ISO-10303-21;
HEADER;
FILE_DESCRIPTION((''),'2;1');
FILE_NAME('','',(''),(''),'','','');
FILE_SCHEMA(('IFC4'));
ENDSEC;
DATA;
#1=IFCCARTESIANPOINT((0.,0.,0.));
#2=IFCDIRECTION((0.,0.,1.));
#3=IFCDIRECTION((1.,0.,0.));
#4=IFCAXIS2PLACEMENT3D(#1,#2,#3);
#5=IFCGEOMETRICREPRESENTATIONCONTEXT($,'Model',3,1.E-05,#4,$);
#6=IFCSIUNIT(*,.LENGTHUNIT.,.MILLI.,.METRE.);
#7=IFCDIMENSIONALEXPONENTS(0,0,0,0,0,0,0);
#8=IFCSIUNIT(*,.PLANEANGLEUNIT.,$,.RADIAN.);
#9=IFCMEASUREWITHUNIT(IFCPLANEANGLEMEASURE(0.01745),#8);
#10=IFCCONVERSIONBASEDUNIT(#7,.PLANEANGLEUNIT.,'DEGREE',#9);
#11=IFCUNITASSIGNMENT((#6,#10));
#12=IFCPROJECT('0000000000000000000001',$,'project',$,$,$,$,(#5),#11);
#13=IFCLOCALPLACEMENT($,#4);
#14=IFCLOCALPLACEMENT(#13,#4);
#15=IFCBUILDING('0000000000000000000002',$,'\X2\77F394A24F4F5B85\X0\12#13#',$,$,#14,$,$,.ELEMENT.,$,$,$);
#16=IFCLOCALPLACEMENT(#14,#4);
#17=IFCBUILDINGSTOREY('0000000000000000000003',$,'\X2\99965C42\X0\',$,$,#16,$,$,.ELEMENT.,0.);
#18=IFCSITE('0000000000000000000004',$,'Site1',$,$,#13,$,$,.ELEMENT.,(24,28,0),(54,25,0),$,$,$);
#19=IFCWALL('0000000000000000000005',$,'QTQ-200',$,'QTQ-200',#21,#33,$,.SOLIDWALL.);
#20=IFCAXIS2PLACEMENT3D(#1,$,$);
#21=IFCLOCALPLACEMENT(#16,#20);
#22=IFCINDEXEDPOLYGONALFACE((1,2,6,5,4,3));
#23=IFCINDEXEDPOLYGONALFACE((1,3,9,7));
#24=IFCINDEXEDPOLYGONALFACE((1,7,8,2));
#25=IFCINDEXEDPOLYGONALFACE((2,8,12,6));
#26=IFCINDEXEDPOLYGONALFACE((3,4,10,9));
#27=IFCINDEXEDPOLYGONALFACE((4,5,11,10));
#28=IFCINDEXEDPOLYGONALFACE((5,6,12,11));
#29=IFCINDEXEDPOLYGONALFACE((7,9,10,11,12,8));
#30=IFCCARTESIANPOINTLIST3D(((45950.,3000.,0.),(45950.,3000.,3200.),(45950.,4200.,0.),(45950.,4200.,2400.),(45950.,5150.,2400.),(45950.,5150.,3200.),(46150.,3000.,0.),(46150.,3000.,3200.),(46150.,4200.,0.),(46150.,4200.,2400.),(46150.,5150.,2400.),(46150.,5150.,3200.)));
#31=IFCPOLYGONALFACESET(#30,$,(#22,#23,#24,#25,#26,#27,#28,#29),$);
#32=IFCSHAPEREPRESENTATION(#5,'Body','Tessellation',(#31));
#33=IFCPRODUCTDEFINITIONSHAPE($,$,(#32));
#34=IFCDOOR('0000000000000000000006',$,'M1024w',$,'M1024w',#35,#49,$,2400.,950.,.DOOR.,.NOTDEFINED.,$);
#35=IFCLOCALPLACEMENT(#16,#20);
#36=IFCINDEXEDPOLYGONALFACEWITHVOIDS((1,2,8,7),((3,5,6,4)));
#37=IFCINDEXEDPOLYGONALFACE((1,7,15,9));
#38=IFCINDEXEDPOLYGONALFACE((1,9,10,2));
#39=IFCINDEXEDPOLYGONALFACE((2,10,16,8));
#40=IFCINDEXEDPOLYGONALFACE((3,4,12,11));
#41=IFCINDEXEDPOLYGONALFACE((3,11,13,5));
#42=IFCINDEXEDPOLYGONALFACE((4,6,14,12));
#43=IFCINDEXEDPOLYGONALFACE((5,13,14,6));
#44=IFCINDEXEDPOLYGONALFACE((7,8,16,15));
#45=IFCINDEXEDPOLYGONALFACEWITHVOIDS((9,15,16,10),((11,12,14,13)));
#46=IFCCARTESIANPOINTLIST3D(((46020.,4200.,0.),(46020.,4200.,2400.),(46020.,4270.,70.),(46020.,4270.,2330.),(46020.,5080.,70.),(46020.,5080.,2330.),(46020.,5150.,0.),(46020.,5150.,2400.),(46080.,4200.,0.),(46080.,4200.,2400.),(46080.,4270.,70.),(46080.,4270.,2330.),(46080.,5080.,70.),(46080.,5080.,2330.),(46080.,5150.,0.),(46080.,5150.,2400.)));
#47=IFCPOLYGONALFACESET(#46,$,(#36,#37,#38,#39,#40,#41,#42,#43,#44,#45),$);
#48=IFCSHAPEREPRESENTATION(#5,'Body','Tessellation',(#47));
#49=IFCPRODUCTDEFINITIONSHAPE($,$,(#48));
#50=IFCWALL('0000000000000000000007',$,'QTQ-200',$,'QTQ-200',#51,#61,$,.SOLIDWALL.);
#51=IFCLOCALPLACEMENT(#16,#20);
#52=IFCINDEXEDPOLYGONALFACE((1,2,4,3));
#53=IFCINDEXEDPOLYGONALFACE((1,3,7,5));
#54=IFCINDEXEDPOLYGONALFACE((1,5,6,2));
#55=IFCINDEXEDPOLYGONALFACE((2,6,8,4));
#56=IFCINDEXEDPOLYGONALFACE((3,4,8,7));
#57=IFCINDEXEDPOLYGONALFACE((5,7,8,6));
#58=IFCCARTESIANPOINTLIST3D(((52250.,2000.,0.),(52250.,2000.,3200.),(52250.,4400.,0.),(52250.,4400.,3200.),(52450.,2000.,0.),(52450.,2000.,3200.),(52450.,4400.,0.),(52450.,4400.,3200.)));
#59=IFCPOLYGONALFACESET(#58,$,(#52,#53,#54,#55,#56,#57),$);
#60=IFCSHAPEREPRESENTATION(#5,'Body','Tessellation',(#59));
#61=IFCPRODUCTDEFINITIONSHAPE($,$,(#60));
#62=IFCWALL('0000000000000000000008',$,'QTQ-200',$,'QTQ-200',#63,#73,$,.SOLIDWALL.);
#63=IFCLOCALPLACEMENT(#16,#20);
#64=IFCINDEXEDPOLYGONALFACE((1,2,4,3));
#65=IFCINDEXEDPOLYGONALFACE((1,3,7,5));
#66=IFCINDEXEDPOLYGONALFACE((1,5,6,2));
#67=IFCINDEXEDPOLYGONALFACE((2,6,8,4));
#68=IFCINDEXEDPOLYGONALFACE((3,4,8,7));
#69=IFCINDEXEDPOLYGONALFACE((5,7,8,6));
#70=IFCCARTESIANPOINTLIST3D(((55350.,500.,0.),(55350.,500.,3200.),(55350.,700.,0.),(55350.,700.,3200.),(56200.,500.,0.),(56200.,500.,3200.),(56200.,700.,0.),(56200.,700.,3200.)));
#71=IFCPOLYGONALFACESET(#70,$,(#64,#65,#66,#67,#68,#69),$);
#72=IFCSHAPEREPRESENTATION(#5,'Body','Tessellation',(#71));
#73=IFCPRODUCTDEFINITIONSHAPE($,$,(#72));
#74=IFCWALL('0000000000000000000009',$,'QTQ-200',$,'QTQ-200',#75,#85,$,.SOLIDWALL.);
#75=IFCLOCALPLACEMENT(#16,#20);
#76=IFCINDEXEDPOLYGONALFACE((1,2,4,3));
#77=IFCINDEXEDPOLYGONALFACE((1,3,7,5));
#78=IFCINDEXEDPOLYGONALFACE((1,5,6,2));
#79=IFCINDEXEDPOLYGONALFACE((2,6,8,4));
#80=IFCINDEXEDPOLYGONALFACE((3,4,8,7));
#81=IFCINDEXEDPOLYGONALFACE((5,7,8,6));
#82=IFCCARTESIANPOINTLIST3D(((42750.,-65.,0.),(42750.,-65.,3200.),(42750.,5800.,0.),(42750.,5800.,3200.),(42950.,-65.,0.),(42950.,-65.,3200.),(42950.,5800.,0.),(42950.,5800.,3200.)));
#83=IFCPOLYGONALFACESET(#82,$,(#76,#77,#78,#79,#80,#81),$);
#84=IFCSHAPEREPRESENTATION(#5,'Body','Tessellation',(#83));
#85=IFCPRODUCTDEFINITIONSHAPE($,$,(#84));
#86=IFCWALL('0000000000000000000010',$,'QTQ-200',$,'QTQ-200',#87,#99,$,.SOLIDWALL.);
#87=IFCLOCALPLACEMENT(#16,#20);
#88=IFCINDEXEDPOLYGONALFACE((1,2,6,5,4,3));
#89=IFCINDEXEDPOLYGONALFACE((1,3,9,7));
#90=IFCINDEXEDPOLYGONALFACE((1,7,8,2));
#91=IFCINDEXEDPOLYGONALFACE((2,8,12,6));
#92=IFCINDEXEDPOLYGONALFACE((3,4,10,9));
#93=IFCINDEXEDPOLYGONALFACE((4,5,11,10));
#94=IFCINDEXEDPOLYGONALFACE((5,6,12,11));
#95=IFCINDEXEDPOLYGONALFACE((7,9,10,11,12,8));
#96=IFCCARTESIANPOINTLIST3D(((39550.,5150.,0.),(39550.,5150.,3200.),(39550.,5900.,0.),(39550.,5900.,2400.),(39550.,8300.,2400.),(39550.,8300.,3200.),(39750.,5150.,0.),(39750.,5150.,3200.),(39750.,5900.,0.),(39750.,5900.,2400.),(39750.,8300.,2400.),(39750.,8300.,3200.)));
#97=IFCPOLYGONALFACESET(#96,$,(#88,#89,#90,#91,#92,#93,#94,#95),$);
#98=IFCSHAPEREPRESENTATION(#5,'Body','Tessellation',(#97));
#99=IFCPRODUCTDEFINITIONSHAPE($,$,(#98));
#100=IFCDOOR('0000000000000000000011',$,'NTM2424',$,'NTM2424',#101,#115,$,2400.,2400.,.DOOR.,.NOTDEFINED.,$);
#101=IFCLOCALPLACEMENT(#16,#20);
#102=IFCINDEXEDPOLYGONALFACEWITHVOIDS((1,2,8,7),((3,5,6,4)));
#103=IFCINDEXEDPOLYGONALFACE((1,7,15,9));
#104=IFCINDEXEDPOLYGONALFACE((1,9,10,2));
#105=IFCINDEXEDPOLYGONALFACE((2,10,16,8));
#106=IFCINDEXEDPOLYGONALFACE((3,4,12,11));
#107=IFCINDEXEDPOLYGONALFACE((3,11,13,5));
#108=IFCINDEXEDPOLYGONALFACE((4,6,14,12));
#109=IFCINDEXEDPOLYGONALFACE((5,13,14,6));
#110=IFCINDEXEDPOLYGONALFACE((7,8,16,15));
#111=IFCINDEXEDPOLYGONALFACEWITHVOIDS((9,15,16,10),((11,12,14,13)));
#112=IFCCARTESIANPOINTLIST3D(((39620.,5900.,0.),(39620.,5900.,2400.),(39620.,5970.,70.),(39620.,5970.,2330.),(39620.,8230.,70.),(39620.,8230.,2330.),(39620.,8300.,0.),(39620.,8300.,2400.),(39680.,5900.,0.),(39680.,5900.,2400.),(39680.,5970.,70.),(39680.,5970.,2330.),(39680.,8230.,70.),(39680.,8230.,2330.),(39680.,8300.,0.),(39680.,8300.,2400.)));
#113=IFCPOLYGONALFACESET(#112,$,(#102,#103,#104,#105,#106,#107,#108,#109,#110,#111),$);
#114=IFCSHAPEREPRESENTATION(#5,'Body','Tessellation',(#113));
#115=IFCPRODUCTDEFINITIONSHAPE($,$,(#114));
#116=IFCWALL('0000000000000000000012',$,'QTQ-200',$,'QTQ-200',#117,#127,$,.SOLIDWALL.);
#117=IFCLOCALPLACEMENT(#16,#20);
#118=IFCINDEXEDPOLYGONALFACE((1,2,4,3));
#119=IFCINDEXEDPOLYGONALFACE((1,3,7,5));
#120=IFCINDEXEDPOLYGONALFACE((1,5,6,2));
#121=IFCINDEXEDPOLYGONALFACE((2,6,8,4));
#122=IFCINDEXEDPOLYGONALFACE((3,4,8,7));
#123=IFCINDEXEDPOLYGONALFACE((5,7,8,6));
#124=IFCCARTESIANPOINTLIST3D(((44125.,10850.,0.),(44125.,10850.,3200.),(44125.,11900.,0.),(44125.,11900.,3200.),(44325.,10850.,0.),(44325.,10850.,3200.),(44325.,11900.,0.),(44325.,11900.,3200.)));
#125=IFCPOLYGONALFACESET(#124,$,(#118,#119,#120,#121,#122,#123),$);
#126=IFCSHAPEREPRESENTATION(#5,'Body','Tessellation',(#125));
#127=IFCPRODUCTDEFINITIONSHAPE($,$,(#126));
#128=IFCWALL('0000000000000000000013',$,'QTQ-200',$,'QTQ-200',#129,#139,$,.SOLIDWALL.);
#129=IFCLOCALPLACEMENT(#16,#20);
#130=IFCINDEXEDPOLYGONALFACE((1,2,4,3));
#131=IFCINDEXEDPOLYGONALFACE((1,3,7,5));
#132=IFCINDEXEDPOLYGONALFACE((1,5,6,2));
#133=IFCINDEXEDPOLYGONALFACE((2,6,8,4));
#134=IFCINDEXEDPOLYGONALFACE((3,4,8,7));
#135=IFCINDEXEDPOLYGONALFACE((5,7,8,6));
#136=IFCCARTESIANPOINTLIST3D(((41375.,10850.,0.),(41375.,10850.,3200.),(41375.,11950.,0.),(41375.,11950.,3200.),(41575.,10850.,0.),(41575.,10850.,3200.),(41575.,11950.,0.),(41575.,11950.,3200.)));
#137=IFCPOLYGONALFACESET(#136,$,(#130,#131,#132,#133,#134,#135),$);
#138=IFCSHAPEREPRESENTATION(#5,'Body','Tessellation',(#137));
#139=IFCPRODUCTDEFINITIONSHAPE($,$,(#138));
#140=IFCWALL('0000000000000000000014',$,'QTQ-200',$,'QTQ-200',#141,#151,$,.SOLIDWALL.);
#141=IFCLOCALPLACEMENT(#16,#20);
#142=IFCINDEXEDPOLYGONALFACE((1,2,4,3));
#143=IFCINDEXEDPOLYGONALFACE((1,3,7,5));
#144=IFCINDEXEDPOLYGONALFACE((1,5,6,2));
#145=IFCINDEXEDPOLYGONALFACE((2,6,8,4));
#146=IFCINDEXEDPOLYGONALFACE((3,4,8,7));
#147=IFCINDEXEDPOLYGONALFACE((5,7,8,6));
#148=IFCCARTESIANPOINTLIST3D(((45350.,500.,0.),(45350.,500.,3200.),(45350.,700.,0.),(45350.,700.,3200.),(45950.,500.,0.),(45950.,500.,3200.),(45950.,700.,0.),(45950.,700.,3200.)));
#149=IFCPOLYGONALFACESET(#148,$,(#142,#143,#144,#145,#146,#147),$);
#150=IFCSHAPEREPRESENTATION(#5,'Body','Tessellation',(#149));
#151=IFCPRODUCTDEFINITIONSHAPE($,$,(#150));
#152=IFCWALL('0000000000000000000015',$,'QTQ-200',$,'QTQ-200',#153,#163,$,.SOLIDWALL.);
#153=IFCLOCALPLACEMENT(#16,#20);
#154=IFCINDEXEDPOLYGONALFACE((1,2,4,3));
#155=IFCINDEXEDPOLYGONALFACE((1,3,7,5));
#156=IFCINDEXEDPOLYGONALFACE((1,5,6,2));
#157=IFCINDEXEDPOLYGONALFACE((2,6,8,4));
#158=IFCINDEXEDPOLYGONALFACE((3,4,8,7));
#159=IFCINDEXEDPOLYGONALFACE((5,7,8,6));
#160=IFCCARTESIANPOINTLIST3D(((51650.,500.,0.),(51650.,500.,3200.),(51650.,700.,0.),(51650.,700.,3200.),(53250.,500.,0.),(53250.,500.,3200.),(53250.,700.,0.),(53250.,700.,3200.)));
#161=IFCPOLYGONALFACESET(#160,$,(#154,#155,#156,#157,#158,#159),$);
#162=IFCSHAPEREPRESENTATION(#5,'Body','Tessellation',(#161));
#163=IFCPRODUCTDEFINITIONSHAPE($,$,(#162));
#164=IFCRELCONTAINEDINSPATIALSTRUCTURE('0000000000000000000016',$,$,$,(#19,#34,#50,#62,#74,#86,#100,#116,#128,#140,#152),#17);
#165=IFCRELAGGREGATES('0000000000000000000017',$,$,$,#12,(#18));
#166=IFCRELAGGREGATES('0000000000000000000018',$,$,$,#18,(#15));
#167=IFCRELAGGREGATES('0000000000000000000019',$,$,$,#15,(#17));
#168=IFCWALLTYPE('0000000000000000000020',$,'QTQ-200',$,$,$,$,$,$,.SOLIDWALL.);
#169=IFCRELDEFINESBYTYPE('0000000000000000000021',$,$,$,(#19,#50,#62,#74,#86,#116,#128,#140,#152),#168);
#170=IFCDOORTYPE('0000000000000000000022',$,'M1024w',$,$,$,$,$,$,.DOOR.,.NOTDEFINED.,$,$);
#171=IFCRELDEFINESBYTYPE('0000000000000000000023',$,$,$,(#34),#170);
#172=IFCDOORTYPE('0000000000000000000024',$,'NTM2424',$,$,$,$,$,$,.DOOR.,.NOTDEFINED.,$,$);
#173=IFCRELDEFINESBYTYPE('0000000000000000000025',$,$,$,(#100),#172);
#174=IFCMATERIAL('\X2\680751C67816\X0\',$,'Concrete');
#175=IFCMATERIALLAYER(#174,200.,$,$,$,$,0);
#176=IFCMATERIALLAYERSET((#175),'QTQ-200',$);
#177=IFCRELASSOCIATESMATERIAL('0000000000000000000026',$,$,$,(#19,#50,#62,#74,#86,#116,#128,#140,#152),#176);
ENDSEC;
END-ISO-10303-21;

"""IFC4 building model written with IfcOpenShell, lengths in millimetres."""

from ifc_helpers import new_model, entity, si_unit, converted_unit, frame, origin_with_axes, place, context, project, spatial, polyline, outline, extrude, material, layer, layer_set, type_object, element, fill, save


model = new_model("IFC4")

# Units and contexts
model_context = context("Model", 3, precision=1e-05, world=origin_with_axes())
ifc_project = project(units=[si_unit("LENGTHUNIT", "METRE", prefix="MILLI"), converted_unit("PLANEANGLEUNIT", "DEGREE", entity("IfcPlaneAngleMeasure", 0.01745), si_unit("PLANEANGLEUNIT", "RADIAN"), dimensions=[0, 0, 0, 0, 0, 0, 0])], contexts=[model_context])

# Site, building, storey
site_placement = place(None, origin_with_axes())
site = spatial("IfcSite", under=ifc_project, at=site_placement, Name="Site1", CompositionType="ELEMENT", RefLatitude=(24, 28, 0), RefLongitude=(54, 25, 0))
building_placement = place(site_placement, origin_with_axes())
building = spatial("IfcBuilding", under=site, at=building_placement, Name="石钢住宅12#13#", CompositionType="ELEMENT")
storey_placement = place(building_placement, origin_with_axes())
storey = spatial("IfcBuildingStorey", under=building, at=storey_placement, Name="首层", CompositionType="ELEMENT", Elevation=0.0)

# Wall, opening, door
ifc_material = material(Name="标准砖", Category="Concrete")
ifc_layer = layer(ifc_material, 200.0, Priority=0)
ifc_layer_set = layer_set([ifc_layer], Name="QTQ-200")
wall_type = type_object("IfcWallType", Name="QTQ-200", PredefinedType="SOLIDWALL")
wall_1_placement = place(storey_placement, origin_with_axes())
wall_1 = element("IfcWall", 1, at=wall_1_placement, inside=storey, type_object=wall_type, material=ifc_layer_set, Name="QTQ-200", ObjectType="QTQ-200", PredefinedType="SOLIDWALL", context=model_context, shape_type="SweptSolid", body=[
    extrude(outline(polyline([(0.0, 0.0), (3200.0, 0.0), (3200.0, 2150.0), (0.0, 2150.0), (0.0, 0.0)])), frame((45950.0, 3000.0, 3200.0), z_axis=(1.0, 0.0, 0.0), x_axis=(0.0, 0.0, -1.0)), (0.0, 0.0, 1.0), 200.0),
])
opening_1_placement = place(storey_placement, origin_with_axes())
opening_1 = element("IfcOpeningElement", 2, at=opening_1_placement, cuts=wall_1, PredefinedType="OPENING", context=model_context, shape_type="SweptSolid", body=[
    extrude(outline(polyline([(0.0, 0.0), (950.0, 0.0), (950.0, 2400.0), (0.0, 2400.0), (0.0, 0.0)])), frame((44950.0, 4200.0, 0.0), z_axis=(1.0, 0.0, 0.0), x_axis=(0.0, 1.0, 0.0)), (0.0, 0.0, 1.0), 2200.0),
])
door_type_1 = type_object("IfcDoorType", Name="M1024w", OperationType="NOTDEFINED", PredefinedType="DOOR")
door_1_placement = place(storey_placement, origin_with_axes())
door_1 = element("IfcDoor", 3, at=door_1_placement, inside=storey, type_object=door_type_1, Name="M1024w", ObjectType="M1024w", OperationType="NOTDEFINED", OverallHeight=2400.0, OverallWidth=950.0, PredefinedType="DOOR", context=model_context, shape_type="SweptSolid", body=[
    extrude(outline(polyline([(-475.0, -1200.0), (475.0, -1200.0), (475.0, 1200.0), (-475.0, 1200.0), (-475.0, -1200.0)]), holes=[polyline([(-405.0, -1130.0), (-405.0, 1130.0), (405.0, 1130.0), (405.0, -1130.0), (-405.0, -1130.0)])]), frame((46020.0, 4675.0, 1200.0), z_axis=(1.0, 0.0, 0.0), x_axis=(0.0, 1.0, 0.0)), (0.0, 0.0, 1.0), 60.0),
])
fill(opening_1, door_1)

# Walls
wall_2_placement = place(storey_placement, origin_with_axes())
element("IfcWall", 4, at=wall_2_placement, inside=storey, type_object=wall_type, material=ifc_layer_set, Name="QTQ-200", ObjectType="QTQ-200", PredefinedType="SOLIDWALL", context=model_context, shape_type="SweptSolid", body=[
    extrude(outline(polyline([(0.0, 0.0), (3200.0, 0.0), (3200.0, 2400.0), (0.0, 2400.0), (0.0, 0.0)])), frame((52250.0, 2000.0, 3200.0), z_axis=(1.0, 0.0, 0.0), x_axis=(0.0, 0.0, -1.0)), (0.0, 0.0, 1.0), 200.0),
])
wall_3_placement = place(storey_placement, origin_with_axes())
element("IfcWall", 5, at=wall_3_placement, inside=storey, type_object=wall_type, material=ifc_layer_set, Name="QTQ-200", ObjectType="QTQ-200", PredefinedType="SOLIDWALL", context=model_context, shape_type="SweptSolid", body=[
    extrude(outline(polyline([(0.0, 0.0), (3200.0, 0.0), (3200.0, 850.0), (0.0, 850.0), (0.0, 0.0)])), frame((56200.0, 500.0, 3200.0), z_axis=(0.0, 1.0, 0.0), x_axis=(0.0, 0.0, -1.0)), (0.0, 0.0, 1.0), 200.0),
])
wall_4_placement = place(storey_placement, origin_with_axes())
element("IfcWall", 6, at=wall_4_placement, inside=storey, type_object=wall_type, material=ifc_layer_set, Name="QTQ-200", ObjectType="QTQ-200", PredefinedType="SOLIDWALL", context=model_context, shape_type="SweptSolid", body=[
    extrude(outline(polyline([(0.0, 0.0), (3200.0, 0.0), (3200.0, 5865.0), (0.0, 5865.0), (0.0, 0.0)])), frame((42750.0, -65.0, 3200.0), z_axis=(1.0, 0.0, 0.0), x_axis=(0.0, 0.0, -1.0)), (0.0, 0.0, 1.0), 200.0),
])

# Wall, opening, door
wall_5_placement = place(storey_placement, origin_with_axes())
wall_5 = element("IfcWall", 7, at=wall_5_placement, inside=storey, type_object=wall_type, material=ifc_layer_set, Name="QTQ-200", ObjectType="QTQ-200", PredefinedType="SOLIDWALL", context=model_context, shape_type="SweptSolid", body=[
    extrude(outline(polyline([(0.0, 0.0), (3200.0, 0.0), (3200.0, 3150.0), (0.0, 3150.0), (0.0, 0.0)])), frame((39550.0, 5150.0, 3200.0), z_axis=(1.0, 0.0, 0.0), x_axis=(0.0, 0.0, -1.0)), (0.0, 0.0, 1.0), 200.0),
])
opening_2_placement = place(storey_placement, origin_with_axes())
opening_2 = element("IfcOpeningElement", 8, at=opening_2_placement, cuts=wall_5, PredefinedType="OPENING", context=model_context, shape_type="SweptSolid", body=[
    extrude(outline(polyline([(0.0, 0.0), (2400.0, 0.0), (2400.0, 2400.0), (0.0, 2400.0), (0.0, 0.0)])), frame((38550.0, 5900.0, 0.0), z_axis=(1.0, 0.0, 0.0), x_axis=(0.0, 1.0, 0.0)), (0.0, 0.0, 1.0), 2200.0),
])
door_type_2 = type_object("IfcDoorType", Name="NTM2424", OperationType="NOTDEFINED", PredefinedType="DOOR")
door_2_placement = place(storey_placement, origin_with_axes())
door_2 = element("IfcDoor", 9, at=door_2_placement, inside=storey, type_object=door_type_2, Name="NTM2424", ObjectType="NTM2424", OperationType="NOTDEFINED", OverallHeight=2400.0, OverallWidth=2400.0, PredefinedType="DOOR", context=model_context, shape_type="SweptSolid", body=[
    extrude(outline(polyline([(-1200.0, -1200.0), (1200.0, -1200.0), (1200.0, 1200.0), (-1200.0, 1200.0), (-1200.0, -1200.0)]), holes=[polyline([(-1130.0, -1130.0), (-1130.0, 1130.0), (1130.0, 1130.0), (1130.0, -1130.0), (-1130.0, -1130.0)])]), frame((39620.0, 7100.0, 1200.0), z_axis=(1.0, 0.0, 0.0), x_axis=(0.0, 1.0, 0.0)), (0.0, 0.0, 1.0), 60.0),
])
fill(opening_2, door_2)

# Walls
wall_6_placement = place(storey_placement, origin_with_axes())
element("IfcWall", 10, at=wall_6_placement, inside=storey, type_object=wall_type, material=ifc_layer_set, Name="QTQ-200", ObjectType="QTQ-200", PredefinedType="SOLIDWALL", context=model_context, shape_type="SweptSolid", body=[
    extrude(outline(polyline([(0.0, 0.0), (3200.0, 0.0), (3200.0, 1050.0), (0.0, 1050.0), (0.0, 0.0)])), frame((44325.0, 11900.0, 3200.0), z_axis=(-1.0, 0.0, 0.0), x_axis=(0.0, 0.0, -1.0)), (0.0, 0.0, 1.0), 200.0),
])
wall_7_placement = place(storey_placement, origin_with_axes())
element("IfcWall", 11, at=wall_7_placement, inside=storey, type_object=wall_type, material=ifc_layer_set, Name="QTQ-200", ObjectType="QTQ-200", PredefinedType="SOLIDWALL", context=model_context, shape_type="SweptSolid", body=[
    extrude(outline(polyline([(0.0, 0.0), (3200.0, 0.0), (3200.0, 1100.0), (0.0, 1100.0), (0.0, 0.0)])), frame((41375.0, 10850.0, 3200.0), z_axis=(1.0, 0.0, 0.0), x_axis=(0.0, 0.0, -1.0)), (0.0, 0.0, 1.0), 200.0),
])
wall_8_placement = place(storey_placement, origin_with_axes())
element("IfcWall", 12, at=wall_8_placement, inside=storey, type_object=wall_type, material=ifc_layer_set, Name="QTQ-200", ObjectType="QTQ-200", PredefinedType="SOLIDWALL", context=model_context, shape_type="SweptSolid", body=[
    extrude(outline(polyline([(0.0, 0.0), (3200.0, 0.0), (3200.0, 600.0), (0.0, 600.0), (0.0, 0.0)])), frame((45950.0, 500.0, 3200.0), z_axis=(0.0, 1.0, 0.0), x_axis=(0.0, 0.0, -1.0)), (0.0, 0.0, 1.0), 200.0),
])
wall_9_placement = place(storey_placement, origin_with_axes())
element("IfcWall", 13, at=wall_9_placement, inside=storey, type_object=wall_type, material=ifc_layer_set, Name="QTQ-200", ObjectType="QTQ-200", PredefinedType="SOLIDWALL", context=model_context, shape_type="SweptSolid", body=[
    extrude(outline(polyline([(0.0, 0.0), (3200.0, 0.0), (3200.0, 1600.0), (0.0, 1600.0), (0.0, 0.0)])), frame((53250.0, 500.0, 3200.0), z_axis=(0.0, 1.0, 0.0), x_axis=(0.0, 0.0, -1.0)), (0.0, 0.0, 1.0), 200.0),
])

save(model, "model.ifc")
